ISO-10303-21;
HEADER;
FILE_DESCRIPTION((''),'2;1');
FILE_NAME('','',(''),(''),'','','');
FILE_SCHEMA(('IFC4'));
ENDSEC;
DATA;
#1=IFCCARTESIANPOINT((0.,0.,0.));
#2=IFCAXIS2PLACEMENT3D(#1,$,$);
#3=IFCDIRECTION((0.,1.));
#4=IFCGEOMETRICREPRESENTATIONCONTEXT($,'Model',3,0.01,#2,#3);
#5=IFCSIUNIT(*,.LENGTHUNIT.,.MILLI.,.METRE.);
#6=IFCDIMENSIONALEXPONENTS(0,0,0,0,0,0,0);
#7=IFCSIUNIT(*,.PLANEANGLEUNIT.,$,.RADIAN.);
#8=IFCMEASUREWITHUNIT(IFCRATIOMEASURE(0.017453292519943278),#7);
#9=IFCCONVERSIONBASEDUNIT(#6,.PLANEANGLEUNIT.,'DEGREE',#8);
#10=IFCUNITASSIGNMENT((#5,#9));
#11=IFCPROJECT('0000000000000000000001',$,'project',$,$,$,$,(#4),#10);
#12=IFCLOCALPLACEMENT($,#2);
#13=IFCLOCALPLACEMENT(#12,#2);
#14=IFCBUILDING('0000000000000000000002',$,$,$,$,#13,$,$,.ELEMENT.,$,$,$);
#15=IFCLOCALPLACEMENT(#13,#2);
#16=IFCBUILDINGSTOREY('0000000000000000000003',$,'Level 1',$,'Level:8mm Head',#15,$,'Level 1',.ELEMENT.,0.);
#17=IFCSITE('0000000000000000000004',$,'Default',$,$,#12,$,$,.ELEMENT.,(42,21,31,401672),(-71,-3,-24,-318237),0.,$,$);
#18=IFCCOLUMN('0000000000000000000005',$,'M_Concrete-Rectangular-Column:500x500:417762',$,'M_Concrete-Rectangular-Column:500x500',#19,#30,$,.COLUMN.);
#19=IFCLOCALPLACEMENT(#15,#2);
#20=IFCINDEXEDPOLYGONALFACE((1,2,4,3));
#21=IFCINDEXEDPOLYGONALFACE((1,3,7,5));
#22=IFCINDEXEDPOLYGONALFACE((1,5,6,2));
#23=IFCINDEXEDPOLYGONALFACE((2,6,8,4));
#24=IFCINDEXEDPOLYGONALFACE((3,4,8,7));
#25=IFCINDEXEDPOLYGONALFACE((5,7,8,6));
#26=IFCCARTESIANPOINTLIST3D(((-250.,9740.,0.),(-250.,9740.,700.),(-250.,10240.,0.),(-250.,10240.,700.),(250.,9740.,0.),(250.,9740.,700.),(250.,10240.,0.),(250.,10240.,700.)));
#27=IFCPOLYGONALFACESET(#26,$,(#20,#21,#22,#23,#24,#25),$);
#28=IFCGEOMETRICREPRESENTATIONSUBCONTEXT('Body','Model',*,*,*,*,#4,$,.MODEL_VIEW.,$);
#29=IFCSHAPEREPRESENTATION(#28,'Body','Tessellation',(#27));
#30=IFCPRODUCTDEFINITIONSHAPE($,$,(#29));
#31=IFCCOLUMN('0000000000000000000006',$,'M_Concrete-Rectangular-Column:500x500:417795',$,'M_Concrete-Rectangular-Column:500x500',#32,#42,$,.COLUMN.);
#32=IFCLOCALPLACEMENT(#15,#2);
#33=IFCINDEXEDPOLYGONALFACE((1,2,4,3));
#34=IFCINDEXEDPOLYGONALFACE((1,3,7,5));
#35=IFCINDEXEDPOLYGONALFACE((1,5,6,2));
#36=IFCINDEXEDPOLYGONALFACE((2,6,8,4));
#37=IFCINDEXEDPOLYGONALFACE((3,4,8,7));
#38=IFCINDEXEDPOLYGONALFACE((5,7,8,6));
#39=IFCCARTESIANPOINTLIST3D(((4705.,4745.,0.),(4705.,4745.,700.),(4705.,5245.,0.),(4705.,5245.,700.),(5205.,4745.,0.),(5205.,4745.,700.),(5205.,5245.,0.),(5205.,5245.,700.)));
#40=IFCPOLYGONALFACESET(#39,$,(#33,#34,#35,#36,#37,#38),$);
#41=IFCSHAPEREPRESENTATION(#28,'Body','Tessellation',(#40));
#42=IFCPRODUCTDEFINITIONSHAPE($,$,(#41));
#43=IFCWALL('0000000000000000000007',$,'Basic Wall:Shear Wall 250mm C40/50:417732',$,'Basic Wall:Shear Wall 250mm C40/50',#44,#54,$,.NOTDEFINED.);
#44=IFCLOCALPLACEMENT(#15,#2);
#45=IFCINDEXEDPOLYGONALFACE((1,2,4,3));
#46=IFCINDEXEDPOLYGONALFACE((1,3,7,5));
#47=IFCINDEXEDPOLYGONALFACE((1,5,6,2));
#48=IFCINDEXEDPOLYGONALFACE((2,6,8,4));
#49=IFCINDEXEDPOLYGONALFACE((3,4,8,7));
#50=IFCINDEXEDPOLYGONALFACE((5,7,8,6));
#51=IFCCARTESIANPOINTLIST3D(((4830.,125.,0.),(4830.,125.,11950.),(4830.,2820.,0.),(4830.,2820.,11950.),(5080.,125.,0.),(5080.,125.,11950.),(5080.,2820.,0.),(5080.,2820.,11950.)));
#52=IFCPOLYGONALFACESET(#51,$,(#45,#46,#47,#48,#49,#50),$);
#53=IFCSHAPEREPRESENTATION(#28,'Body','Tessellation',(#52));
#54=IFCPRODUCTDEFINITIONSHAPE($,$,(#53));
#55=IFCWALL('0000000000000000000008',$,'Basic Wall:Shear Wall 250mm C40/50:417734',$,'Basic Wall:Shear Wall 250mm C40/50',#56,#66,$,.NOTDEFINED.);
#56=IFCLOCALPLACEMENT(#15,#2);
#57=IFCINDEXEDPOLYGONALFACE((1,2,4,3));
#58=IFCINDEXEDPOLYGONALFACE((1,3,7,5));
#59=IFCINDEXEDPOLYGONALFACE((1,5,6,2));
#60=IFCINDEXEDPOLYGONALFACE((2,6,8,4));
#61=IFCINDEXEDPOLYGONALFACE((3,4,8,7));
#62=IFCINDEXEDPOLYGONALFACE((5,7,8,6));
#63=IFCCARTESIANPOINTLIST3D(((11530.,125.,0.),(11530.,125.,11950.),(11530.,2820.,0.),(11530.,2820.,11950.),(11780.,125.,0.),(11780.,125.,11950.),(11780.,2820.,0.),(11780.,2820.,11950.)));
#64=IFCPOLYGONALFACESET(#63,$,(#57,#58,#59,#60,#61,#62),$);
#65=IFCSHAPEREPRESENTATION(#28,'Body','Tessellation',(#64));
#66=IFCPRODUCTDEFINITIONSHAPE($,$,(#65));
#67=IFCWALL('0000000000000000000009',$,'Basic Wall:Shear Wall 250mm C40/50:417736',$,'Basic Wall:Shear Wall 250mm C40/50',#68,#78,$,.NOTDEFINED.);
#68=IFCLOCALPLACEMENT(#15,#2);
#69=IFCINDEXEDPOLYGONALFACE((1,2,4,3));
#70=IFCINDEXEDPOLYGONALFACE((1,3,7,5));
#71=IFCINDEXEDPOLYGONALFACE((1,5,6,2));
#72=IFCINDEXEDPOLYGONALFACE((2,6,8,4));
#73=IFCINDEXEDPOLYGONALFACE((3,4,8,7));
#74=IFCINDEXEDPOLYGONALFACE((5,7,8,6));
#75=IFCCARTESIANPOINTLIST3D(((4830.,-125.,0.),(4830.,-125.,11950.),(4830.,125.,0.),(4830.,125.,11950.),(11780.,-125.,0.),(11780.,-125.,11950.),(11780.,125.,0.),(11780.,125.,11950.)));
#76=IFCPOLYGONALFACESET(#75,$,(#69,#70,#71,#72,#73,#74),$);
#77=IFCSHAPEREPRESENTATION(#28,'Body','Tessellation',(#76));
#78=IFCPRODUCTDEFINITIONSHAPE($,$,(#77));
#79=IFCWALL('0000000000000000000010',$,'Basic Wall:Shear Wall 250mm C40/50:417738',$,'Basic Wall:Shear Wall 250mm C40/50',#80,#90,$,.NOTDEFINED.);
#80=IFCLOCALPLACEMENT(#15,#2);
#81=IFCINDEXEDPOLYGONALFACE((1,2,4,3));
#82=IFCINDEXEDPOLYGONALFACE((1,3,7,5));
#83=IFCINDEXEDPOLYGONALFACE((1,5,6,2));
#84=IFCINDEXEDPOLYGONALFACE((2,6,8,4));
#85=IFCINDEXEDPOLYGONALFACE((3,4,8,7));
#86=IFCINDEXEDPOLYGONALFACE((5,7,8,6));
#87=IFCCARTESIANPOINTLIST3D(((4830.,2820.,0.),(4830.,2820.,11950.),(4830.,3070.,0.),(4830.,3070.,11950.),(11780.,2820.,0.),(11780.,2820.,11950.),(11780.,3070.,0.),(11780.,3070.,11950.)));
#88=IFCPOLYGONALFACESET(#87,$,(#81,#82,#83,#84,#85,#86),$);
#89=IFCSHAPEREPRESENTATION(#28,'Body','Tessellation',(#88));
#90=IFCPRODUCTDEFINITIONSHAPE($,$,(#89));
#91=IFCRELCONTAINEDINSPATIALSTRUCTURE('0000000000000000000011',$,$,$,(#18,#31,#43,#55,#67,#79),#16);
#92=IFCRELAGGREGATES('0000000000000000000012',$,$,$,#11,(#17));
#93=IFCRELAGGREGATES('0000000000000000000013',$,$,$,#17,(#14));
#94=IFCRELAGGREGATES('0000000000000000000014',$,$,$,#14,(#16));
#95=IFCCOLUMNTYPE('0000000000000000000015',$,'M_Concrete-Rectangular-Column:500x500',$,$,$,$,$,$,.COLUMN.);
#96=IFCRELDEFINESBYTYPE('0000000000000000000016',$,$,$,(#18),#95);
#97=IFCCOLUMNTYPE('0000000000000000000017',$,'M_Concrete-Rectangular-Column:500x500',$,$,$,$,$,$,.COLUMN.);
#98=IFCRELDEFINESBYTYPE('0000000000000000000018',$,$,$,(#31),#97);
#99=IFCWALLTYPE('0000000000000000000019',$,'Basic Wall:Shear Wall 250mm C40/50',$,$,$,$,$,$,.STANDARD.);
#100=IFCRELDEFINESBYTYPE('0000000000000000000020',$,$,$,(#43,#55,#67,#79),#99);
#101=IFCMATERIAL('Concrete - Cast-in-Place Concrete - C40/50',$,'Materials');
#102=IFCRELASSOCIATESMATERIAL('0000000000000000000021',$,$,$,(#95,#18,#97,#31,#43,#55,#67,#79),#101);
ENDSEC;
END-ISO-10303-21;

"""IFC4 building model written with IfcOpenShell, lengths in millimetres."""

from ifc_helpers import new_model, entity, si_unit, converted_unit, direction, frame, origin, place, context, subcontext, project, spatial, indexed_curve, outline, extrude, source, transform, mapped, material, type_object, type_shapes, element, save


model = new_model("IFC4")

# Units and contexts
model_context = context("Model", 3, precision=0.01, world=origin(), true_north=direction((0.0, 1.0)))
body_context = subcontext(model_context, "Body", "Model", "MODEL_VIEW")
ifc_project = project(units=[si_unit("LENGTHUNIT", "METRE", prefix="MILLI"), converted_unit("PLANEANGLEUNIT", "DEGREE", entity("IfcRatioMeasure", 0.017453292519943278), si_unit("PLANEANGLEUNIT", "RADIAN"), dimensions=[0, 0, 0, 0, 0, 0, 0])], contexts=[model_context])

# Site, building, storey
site_placement = place(None, origin())
site = spatial("IfcSite", under=ifc_project, at=site_placement, Name="Default", CompositionType="ELEMENT", RefLatitude=(42, 21, 31, 401672), RefLongitude=(-71, -3, -24, -318237), RefElevation=0.0)
building_placement = place(site_placement, origin())
building = spatial("IfcBuilding", under=site, at=building_placement, CompositionType="ELEMENT")
storey_placement = place(building_placement, origin())
storey = spatial("IfcBuildingStorey", under=building, at=storey_placement, Name="Level 1", ObjectType="Level:8mm Head", LongName="Level 1", CompositionType="ELEMENT", Elevation=0.0)

# Columns
ifc_material = material(Name="Concrete - Cast-in-Place Concrete - C40/50", Category="Materials")
column_type_1 = type_object("IfcColumnType", Name="M_Concrete-Rectangular-Column:500x500", PredefinedType="COLUMN", material=ifc_material)
shared_shape_1 = source(origin(), body_context, "Body", "SweptSolid", [
    extrude(outline(indexed_curve([(-250.0, -250.0), (250.0, -250.0), (250.0, 250.0), (-250.0, 250.0), (-250.0, -250.0)], self_intersect=False)), frame((0.0, 9990.0, 0.0), z_axis=(0.0, 0.0, 1.0), x_axis=(0.0, -1.0, 0.0)), (0.0, 0.0, 1.0), 700.0),
])
type_shapes(column_type_1, [shared_shape_1])
column_1_placement = place(storey_placement, origin())
element("IfcColumn", 1, at=column_1_placement, inside=storey, type_object=column_type_1, material=ifc_material, Name="M_Concrete-Rectangular-Column:500x500:417762", ObjectType="M_Concrete-Rectangular-Column:500x500", PredefinedType="COLUMN", context=body_context, shape_type="MappedRepresentation", body=[
    mapped(shared_shape_1, transform((0.0, 0.0, 0.0), scale=1.0)),
])
column_type_2 = type_object("IfcColumnType", Name="M_Concrete-Rectangular-Column:500x500", PredefinedType="COLUMN", material=ifc_material)
shared_shape_2 = source(origin(), body_context, "Body", "SweptSolid", [
    extrude(outline(indexed_curve([(-250.0, -250.0), (250.0, -250.0), (250.0, 250.0), (-250.0, 250.0), (-250.0, -250.0)], self_intersect=False)), frame((4955.0, 4995.0, 0.0), z_axis=(0.0, 0.0, 1.0), x_axis=(0.0, -1.0, 0.0)), (0.0, 0.0, 1.0), 700.0),
])
type_shapes(column_type_2, [shared_shape_2])
column_2_placement = place(storey_placement, origin())
element("IfcColumn", 2, at=column_2_placement, inside=storey, type_object=column_type_2, material=ifc_material, Name="M_Concrete-Rectangular-Column:500x500:417795", ObjectType="M_Concrete-Rectangular-Column:500x500", PredefinedType="COLUMN", context=body_context, shape_type="MappedRepresentation", body=[
    mapped(shared_shape_2, transform((0.0, 0.0, 0.0), scale=1.0)),
])

# Walls
wall_type = type_object("IfcWallType", Name="Basic Wall:Shear Wall 250mm C40/50", PredefinedType="STANDARD")
wall_1_placement = place(storey_placement, frame((4955.0, 2820.0, 0.0), z_axis=(0.0, 0.0, 1.0), x_axis=(0.0, -1.0, 0.0)))
element("IfcWall", 3, at=wall_1_placement, inside=storey, type_object=wall_type, material=ifc_material, Name="Basic Wall:Shear Wall 250mm C40/50:417732", ObjectType="Basic Wall:Shear Wall 250mm C40/50", PredefinedType="NOTDEFINED", context=body_context, shape_type="SweptSolid", body=[
    extrude(outline(indexed_curve([(2695.0, 125.0), (0.0, 125.0), (0.0, -125.0), (2695.0, -125.0), (2695.0, 125.0)], self_intersect=False)), origin(), (0.0, 0.0, 1.0), 11950.0),
])
wall_2_placement = place(storey_placement, frame((11655.0, 2820.0, 0.0), z_axis=(0.0, 0.0, 1.0), x_axis=(0.0, -1.0, 0.0)))
element("IfcWall", 4, at=wall_2_placement, inside=storey, type_object=wall_type, material=ifc_material, Name="Basic Wall:Shear Wall 250mm C40/50:417734", ObjectType="Basic Wall:Shear Wall 250mm C40/50", PredefinedType="NOTDEFINED", context=body_context, shape_type="SweptSolid", body=[
    extrude(outline(indexed_curve([(2695.0, 125.0), (0.0, 125.0), (0.0, -125.0), (2695.0, -125.0), (2695.0, 125.0)], self_intersect=False)), origin(), (0.0, 0.0, 1.0), 11950.0),
])
wall_3_placement = place(storey_placement, frame((11780.0, 0.0, 0.0), z_axis=(0.0, 0.0, 1.0), x_axis=(-1.0, 0.0, 0.0)))
element("IfcWall", 5, at=wall_3_placement, inside=storey, type_object=wall_type, material=ifc_material, Name="Basic Wall:Shear Wall 250mm C40/50:417736", ObjectType="Basic Wall:Shear Wall 250mm C40/50", PredefinedType="NOTDEFINED", context=body_context, shape_type="SweptSolid", body=[
    extrude(outline(indexed_curve([(6950.0, 125.0), (0.0, 125.0), (0.0, -125.0), (6950.0, -125.0), (6950.0, 125.0)], self_intersect=False)), origin(), (0.0, 0.0, 1.0), 11950.0),
])
wall_4_placement = place(storey_placement, frame((11780.0, 2945.0, 0.0), z_axis=(0.0, 0.0, 1.0), x_axis=(-1.0, 0.0, 0.0)))
element("IfcWall", 6, at=wall_4_placement, inside=storey, type_object=wall_type, material=ifc_material, Name="Basic Wall:Shear Wall 250mm C40/50:417738", ObjectType="Basic Wall:Shear Wall 250mm C40/50", PredefinedType="NOTDEFINED", context=body_context, shape_type="SweptSolid", body=[
    extrude(outline(indexed_curve([(6950.0, 125.0), (0.0, 125.0), (0.0, -125.0), (6950.0, -125.0), (6950.0, 125.0)], self_intersect=False)), origin(), (0.0, 0.0, 1.0), 11950.0),
])

save(model, "model.ifc")
